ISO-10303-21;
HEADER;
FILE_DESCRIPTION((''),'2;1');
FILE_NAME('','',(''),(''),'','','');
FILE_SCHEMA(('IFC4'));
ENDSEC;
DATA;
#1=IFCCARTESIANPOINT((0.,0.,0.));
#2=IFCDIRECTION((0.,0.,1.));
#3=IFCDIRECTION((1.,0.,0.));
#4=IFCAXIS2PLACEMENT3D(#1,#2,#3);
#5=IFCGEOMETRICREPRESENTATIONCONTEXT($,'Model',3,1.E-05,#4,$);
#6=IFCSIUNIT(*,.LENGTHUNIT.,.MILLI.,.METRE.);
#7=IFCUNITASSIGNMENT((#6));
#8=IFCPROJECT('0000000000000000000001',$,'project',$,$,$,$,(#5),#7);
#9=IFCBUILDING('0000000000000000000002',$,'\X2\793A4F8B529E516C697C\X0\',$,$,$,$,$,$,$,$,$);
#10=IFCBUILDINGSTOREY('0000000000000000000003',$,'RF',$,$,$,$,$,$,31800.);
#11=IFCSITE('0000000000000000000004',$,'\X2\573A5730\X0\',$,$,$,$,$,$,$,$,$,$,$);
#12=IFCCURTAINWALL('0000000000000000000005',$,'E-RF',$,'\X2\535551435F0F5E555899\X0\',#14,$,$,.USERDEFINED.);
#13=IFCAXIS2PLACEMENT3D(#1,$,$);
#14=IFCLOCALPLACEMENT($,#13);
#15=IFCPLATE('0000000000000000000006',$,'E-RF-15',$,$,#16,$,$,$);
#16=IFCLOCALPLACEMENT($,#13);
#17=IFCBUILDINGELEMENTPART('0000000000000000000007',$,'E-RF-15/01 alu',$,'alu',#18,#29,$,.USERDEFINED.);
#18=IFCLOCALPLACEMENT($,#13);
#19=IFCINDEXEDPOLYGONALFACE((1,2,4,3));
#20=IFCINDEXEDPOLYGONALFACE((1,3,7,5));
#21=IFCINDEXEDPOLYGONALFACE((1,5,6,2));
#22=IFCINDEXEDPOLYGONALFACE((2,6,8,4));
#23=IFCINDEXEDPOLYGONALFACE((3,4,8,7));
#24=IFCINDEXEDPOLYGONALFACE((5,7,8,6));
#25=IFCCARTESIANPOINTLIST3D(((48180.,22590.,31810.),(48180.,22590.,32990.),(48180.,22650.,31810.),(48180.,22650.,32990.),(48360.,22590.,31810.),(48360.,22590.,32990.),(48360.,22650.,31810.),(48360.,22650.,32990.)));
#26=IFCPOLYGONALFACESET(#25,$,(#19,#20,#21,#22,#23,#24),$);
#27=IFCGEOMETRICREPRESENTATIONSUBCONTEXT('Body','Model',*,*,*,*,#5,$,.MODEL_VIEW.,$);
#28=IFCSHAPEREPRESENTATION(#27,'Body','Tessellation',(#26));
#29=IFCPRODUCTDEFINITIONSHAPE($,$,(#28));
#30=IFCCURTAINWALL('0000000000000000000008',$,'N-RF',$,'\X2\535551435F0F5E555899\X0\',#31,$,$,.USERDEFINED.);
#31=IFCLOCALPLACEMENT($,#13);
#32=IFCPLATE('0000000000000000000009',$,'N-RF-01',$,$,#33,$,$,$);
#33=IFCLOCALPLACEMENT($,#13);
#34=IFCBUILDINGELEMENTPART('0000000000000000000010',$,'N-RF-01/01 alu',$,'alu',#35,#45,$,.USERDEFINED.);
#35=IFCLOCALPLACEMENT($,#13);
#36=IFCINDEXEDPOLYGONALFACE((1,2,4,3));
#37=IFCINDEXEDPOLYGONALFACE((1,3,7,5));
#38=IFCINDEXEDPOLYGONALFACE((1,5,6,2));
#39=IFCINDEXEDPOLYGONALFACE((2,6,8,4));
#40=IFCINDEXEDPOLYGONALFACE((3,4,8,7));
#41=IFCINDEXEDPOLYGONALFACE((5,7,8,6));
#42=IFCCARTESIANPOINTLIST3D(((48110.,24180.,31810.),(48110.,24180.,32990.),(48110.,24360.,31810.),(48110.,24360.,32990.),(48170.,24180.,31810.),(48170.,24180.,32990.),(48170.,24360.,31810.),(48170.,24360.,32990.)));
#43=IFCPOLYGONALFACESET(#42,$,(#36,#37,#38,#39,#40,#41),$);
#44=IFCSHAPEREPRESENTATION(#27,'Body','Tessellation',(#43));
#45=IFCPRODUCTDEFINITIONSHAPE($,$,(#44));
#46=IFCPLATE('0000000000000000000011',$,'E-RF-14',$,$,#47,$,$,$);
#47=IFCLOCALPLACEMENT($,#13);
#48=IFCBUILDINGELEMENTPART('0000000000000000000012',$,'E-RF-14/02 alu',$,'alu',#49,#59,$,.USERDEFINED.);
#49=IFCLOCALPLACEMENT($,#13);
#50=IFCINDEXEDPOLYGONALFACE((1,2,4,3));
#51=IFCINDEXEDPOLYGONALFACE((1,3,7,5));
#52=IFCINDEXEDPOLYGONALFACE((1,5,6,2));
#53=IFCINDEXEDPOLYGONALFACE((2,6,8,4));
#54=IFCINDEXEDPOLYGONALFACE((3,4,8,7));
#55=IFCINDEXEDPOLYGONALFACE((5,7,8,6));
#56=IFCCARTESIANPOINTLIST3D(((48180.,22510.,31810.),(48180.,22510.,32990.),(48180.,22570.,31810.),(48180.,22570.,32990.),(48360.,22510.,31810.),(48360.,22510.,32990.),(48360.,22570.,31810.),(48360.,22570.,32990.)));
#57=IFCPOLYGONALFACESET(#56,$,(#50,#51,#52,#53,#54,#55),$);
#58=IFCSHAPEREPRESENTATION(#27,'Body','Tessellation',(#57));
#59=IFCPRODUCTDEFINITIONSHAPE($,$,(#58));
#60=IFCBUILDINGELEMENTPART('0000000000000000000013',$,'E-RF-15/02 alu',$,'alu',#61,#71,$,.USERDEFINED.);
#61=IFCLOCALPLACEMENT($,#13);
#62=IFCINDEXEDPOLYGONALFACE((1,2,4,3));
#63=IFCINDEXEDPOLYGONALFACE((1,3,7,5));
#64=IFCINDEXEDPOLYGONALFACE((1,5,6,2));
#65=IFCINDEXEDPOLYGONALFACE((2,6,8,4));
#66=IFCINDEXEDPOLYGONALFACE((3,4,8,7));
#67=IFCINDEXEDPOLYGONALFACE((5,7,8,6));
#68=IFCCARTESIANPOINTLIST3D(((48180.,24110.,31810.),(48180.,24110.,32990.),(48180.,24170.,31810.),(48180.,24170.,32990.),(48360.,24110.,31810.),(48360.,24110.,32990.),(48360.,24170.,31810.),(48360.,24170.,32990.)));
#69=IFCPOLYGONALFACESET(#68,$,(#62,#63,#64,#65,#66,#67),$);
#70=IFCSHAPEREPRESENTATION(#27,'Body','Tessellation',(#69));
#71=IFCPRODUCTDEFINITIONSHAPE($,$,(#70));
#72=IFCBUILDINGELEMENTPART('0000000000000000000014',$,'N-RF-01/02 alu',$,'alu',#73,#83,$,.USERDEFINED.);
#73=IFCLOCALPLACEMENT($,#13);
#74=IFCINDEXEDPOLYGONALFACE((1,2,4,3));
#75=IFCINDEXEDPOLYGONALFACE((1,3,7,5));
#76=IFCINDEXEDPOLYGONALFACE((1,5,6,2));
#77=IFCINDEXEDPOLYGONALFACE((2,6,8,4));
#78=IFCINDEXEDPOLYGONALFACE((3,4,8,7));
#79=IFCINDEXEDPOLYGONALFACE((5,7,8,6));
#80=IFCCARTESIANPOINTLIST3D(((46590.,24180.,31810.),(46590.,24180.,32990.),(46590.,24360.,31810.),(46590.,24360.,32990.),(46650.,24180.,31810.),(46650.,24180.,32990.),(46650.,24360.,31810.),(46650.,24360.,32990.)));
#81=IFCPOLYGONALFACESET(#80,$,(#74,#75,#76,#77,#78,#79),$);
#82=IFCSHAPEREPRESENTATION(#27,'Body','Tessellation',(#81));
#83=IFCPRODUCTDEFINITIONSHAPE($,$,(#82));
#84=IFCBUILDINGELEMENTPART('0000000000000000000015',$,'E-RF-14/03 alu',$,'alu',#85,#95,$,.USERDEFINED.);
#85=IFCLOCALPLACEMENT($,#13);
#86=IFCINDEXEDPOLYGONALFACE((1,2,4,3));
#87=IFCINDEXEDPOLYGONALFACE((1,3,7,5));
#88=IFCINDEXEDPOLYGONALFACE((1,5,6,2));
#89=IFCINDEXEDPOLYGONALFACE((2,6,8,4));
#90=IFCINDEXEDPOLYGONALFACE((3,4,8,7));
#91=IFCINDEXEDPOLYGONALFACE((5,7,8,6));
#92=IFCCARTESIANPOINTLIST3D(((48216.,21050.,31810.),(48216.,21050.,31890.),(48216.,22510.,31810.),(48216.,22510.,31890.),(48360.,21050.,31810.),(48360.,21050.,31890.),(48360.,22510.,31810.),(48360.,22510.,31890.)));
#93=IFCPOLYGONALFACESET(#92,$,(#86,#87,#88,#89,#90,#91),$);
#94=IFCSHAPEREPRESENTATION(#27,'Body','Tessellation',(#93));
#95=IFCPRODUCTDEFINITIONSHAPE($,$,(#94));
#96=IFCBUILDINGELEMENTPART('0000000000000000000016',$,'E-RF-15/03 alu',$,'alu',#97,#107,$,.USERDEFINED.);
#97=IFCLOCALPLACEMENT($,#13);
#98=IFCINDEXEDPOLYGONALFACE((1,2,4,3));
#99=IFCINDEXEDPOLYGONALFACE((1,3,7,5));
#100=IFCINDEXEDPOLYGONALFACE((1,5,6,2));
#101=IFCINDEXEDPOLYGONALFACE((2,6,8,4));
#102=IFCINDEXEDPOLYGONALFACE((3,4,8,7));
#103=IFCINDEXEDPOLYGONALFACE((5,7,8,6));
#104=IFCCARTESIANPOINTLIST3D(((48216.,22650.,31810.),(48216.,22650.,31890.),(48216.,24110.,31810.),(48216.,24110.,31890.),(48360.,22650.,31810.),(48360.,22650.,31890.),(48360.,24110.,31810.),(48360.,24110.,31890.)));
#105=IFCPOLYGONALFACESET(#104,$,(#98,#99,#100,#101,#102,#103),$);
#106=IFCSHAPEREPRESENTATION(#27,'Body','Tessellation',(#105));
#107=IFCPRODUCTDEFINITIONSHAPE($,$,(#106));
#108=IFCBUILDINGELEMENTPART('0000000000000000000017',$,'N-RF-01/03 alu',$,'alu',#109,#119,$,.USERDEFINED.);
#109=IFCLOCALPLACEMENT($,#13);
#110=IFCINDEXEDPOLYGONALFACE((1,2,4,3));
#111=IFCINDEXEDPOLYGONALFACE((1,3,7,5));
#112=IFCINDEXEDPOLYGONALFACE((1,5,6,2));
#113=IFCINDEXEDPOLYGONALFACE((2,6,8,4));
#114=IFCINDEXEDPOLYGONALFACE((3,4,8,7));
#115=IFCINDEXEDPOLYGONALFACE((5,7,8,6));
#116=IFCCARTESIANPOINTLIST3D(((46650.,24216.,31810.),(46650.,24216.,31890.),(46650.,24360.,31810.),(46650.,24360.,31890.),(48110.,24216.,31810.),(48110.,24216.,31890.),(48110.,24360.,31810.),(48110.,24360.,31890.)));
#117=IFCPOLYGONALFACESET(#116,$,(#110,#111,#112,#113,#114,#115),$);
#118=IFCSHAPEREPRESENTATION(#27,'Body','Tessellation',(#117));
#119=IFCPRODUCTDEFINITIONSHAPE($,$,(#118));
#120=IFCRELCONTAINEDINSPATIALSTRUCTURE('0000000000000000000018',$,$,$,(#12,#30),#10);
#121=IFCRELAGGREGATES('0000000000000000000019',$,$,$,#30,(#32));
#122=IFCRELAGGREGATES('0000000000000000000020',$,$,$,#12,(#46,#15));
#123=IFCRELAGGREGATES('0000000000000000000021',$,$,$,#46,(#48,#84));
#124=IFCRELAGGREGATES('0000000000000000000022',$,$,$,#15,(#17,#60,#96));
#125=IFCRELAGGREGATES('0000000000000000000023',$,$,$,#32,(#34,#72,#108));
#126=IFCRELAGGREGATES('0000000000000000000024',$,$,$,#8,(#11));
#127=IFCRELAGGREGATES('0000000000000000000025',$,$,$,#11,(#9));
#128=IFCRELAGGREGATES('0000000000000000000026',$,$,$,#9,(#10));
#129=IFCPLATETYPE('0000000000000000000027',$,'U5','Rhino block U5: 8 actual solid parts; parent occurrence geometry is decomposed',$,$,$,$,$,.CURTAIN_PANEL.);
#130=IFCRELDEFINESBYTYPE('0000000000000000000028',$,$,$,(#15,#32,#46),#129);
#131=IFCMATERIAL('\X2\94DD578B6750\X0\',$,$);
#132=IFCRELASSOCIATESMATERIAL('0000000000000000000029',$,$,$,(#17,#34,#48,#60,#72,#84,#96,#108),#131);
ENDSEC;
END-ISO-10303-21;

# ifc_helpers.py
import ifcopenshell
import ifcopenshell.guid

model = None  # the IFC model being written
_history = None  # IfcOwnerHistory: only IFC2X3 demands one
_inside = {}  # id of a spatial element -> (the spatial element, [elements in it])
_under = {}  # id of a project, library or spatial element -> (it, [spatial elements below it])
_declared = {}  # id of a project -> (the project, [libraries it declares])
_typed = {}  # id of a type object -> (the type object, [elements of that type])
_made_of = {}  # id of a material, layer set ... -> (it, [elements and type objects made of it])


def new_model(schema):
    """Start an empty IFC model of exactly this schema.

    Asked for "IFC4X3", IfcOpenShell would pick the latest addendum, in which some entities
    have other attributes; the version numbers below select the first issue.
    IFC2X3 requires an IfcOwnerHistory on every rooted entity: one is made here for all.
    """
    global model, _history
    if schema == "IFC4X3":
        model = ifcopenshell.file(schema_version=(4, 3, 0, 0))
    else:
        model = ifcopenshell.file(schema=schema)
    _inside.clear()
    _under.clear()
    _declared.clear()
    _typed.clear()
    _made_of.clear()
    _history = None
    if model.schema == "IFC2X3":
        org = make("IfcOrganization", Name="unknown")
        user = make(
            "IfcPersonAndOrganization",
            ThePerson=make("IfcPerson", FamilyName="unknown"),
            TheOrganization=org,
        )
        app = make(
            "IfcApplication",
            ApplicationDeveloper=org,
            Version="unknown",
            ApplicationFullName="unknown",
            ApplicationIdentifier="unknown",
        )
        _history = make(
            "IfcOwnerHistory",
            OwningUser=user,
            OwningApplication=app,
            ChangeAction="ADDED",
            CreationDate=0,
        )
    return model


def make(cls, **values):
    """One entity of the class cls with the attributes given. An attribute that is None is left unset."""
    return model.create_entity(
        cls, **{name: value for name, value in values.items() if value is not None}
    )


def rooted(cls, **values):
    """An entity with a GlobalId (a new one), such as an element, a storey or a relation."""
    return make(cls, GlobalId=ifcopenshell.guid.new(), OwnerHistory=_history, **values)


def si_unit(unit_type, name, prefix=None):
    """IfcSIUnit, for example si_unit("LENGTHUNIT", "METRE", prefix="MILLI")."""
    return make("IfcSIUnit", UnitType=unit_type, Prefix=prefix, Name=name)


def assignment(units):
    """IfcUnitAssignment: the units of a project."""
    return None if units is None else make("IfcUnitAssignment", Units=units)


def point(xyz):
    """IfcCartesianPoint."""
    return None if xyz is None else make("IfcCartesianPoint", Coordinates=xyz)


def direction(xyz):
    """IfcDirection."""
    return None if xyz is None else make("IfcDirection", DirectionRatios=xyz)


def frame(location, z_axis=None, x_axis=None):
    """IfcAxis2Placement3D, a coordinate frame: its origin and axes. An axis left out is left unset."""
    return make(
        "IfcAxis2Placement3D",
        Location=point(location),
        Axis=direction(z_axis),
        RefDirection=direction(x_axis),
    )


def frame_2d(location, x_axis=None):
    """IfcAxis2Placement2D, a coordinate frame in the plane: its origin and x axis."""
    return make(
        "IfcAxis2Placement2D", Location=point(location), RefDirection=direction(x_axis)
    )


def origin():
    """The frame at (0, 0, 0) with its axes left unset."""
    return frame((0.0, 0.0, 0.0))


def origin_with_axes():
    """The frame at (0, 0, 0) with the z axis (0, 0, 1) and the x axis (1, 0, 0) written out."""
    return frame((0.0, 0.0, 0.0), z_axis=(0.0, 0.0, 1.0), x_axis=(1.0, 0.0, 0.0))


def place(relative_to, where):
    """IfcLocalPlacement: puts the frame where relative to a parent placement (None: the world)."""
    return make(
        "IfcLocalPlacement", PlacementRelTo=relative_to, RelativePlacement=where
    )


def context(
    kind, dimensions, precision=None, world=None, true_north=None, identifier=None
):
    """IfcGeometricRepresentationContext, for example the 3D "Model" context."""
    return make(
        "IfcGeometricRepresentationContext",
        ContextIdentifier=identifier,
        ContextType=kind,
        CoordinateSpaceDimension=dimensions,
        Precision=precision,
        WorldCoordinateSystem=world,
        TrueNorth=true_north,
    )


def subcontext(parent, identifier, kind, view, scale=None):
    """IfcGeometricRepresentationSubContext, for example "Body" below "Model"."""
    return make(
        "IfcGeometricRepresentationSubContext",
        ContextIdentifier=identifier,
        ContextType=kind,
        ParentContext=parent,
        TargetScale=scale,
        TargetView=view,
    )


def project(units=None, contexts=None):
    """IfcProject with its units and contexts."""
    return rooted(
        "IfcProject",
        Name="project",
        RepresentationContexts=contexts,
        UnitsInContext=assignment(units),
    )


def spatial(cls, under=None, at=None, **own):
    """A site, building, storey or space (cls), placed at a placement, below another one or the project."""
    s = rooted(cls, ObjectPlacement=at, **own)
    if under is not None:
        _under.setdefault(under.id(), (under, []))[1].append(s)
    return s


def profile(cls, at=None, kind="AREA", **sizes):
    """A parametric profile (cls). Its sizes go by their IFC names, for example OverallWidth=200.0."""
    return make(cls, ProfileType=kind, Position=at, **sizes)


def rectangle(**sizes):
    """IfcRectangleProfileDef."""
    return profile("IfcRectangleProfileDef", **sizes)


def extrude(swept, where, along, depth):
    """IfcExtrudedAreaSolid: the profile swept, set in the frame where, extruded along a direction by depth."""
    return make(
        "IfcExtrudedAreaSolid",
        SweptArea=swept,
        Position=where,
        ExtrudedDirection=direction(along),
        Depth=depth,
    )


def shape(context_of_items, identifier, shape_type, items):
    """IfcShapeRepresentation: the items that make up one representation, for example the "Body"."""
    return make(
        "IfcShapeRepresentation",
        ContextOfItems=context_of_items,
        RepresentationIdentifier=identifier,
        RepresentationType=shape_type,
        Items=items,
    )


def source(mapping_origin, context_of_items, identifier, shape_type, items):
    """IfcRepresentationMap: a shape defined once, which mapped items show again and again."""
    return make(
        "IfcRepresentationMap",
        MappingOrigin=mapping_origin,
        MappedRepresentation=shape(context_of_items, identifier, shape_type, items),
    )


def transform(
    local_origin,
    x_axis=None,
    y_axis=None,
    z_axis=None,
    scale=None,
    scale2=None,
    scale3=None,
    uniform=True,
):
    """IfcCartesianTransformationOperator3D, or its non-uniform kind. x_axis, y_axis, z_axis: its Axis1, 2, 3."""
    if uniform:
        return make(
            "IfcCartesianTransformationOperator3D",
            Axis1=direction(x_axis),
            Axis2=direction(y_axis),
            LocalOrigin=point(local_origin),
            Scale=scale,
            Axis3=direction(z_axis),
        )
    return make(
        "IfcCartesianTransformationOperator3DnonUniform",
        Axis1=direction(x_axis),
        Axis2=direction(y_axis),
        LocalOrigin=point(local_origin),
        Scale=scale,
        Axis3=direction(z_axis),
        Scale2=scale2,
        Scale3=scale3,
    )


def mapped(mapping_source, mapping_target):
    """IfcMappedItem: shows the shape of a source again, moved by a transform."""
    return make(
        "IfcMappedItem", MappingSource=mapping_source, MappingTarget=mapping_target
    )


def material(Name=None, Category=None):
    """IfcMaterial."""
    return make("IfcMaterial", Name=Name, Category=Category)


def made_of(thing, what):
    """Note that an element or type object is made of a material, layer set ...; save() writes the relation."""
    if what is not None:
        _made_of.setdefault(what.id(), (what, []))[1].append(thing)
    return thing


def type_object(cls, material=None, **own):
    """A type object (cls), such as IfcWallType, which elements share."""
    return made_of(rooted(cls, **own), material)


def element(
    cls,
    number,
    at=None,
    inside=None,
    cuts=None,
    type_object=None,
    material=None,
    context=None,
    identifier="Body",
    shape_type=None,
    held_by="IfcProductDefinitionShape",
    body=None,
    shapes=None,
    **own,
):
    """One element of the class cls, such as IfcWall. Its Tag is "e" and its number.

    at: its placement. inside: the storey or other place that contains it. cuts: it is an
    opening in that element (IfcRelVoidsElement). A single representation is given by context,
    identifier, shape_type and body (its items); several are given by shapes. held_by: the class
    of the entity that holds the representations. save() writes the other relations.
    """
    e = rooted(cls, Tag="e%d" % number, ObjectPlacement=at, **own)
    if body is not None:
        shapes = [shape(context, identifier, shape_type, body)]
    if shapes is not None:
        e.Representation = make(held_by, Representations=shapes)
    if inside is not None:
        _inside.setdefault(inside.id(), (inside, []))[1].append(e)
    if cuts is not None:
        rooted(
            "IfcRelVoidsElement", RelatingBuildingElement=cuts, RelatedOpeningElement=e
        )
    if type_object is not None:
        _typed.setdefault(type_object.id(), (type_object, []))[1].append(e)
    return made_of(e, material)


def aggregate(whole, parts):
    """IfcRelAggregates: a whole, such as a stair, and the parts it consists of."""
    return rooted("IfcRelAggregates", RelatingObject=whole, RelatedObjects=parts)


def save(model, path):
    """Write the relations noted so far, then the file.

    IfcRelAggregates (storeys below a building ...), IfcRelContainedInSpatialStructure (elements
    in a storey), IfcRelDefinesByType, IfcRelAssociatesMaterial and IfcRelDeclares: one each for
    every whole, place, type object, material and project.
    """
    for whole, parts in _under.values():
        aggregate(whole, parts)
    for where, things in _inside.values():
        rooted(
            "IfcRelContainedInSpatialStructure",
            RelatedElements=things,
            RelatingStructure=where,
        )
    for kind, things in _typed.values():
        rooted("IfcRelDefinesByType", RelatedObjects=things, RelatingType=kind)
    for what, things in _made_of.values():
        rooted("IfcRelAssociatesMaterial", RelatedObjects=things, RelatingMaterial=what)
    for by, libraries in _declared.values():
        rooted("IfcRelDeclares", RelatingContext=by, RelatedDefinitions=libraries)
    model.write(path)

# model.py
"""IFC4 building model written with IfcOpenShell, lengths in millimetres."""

from ifc_helpers import new_model, si_unit, frame, frame_2d, origin, origin_with_axes, place, context, subcontext, project, spatial, rectangle, extrude, source, transform, mapped, material, type_object, element, aggregate, save


model = new_model("IFC4")

# Units and contexts
model_context = context("Model", 3, precision=1e-05, world=origin_with_axes())
body_context = subcontext(model_context, "Body", "Model", "MODEL_VIEW")
ifc_project = project(units=[si_unit("LENGTHUNIT", "METRE", prefix="MILLI")], contexts=[model_context])

# Site, building, storey
site = spatial("IfcSite", under=ifc_project, Name="场地")
building = spatial("IfcBuilding", under=site, Name="示例办公楼")
storey = spatial("IfcBuildingStorey", under=building, Name="RF", Elevation=31800.0)

# Curtain walls, plates, building element parts
curtain_wall_1 = element("IfcCurtainWall", 1, inside=storey, Name="E-RF", ObjectType="单元式幕墙", PredefinedType="USERDEFINED")
plate_type = type_object("IfcPlateType", Name="U5", Description="Rhino block U5: 8 actual solid parts; parent occurrence geometry is decomposed", PredefinedType="CURTAIN_PANEL")
plate_1_placement = place(None, frame((48360.0, 22590.0, 31810.0), z_axis=(0.0, 0.0, 1.0), x_axis=(0.0, 1.0, 0.0)))
plate_1 = element("IfcPlate", 2, at=plate_1_placement, type_object=plate_type, Name="E-RF-15")
ifc_material_1 = material(Name="铝型材")
shared_shape_1 = source(origin(), body_context, "Body", "SweptSolid", [
    extrude(rectangle(XDim=60.0, YDim=180.0, at=frame_2d((30.0, 90.0))), origin(), (0.0, 0.0, 1.0), 1180.0),
])
building_element_part_1_placement = place(plate_1_placement, origin())
building_element_part_1 = element("IfcBuildingElementPart", 3, at=building_element_part_1_placement, material=ifc_material_1, Name="E-RF-15/01 alu", ObjectType="alu", PredefinedType="USERDEFINED", context=body_context, shape_type="MappedRepresentation", body=[
    mapped(shared_shape_1, transform((0.0, 0.0, 0.0))),
])
curtain_wall_2 = element("IfcCurtainWall", 4, inside=storey, Name="N-RF", ObjectType="单元式幕墙", PredefinedType="USERDEFINED")
plate_2_placement = place(None, frame((48170.0, 24360.0, 31810.0), z_axis=(0.0, 0.0, 1.0), x_axis=(-1.0, 0.0, 0.0)))
plate_2 = element("IfcPlate", 5, at=plate_2_placement, type_object=plate_type, Name="N-RF-01")
aggregate(curtain_wall_2, [plate_2])
building_element_part_2_placement = place(plate_2_placement, origin())
building_element_part_2 = element("IfcBuildingElementPart", 6, at=building_element_part_2_placement, material=ifc_material_1, Name="N-RF-01/01 alu", ObjectType="alu", PredefinedType="USERDEFINED", context=body_context, shape_type="MappedRepresentation", body=[
    mapped(shared_shape_1, transform((0.0, 0.0, 0.0))),
])

# Plate
plate_3_placement = place(None, frame((48360.0, 20990.0, 31810.0), z_axis=(0.0, 0.0, 1.0), x_axis=(0.0, 1.0, 0.0)))
plate_3 = element("IfcPlate", 7, at=plate_3_placement, type_object=plate_type, Name="E-RF-14")
aggregate(curtain_wall_1, [plate_3, plate_1])

# Building element parts
shared_shape_2 = source(origin(), body_context, "Body", "SweptSolid", [
    extrude(rectangle(XDim=60.0, YDim=180.0, at=frame_2d((1550.0, 90.0))), origin(), (0.0, 0.0, 1.0), 1180.0),
])
building_element_part_3_placement = place(plate_3_placement, origin())
building_element_part_3 = element("IfcBuildingElementPart", 8, at=building_element_part_3_placement, material=ifc_material_1, Name="E-RF-14/02 alu", ObjectType="alu", PredefinedType="USERDEFINED", context=body_context, shape_type="MappedRepresentation", body=[
    mapped(shared_shape_2, transform((0.0, 0.0, 0.0))),
])
building_element_part_4_placement = place(plate_1_placement, origin())
building_element_part_4 = element("IfcBuildingElementPart", 9, at=building_element_part_4_placement, material=ifc_material_1, Name="E-RF-15/02 alu", ObjectType="alu", PredefinedType="USERDEFINED", context=body_context, shape_type="MappedRepresentation", body=[
    mapped(shared_shape_2, transform((0.0, 0.0, 0.0))),
])
building_element_part_5_placement = place(plate_2_placement, origin())
building_element_part_5 = element("IfcBuildingElementPart", 10, at=building_element_part_5_placement, material=ifc_material_1, Name="N-RF-01/02 alu", ObjectType="alu", PredefinedType="USERDEFINED", context=body_context, shape_type="MappedRepresentation", body=[
    mapped(shared_shape_2, transform((0.0, 0.0, 0.0))),
])
shared_shape_3 = source(origin(), body_context, "Body", "SweptSolid", [
    extrude(rectangle(XDim=1460.0, YDim=144.0, at=frame_2d((790.0, 72.0))), origin(), (0.0, 0.0, 1.0), 80.0),
])
building_element_part_6_placement = place(plate_3_placement, origin())
building_element_part_6 = element("IfcBuildingElementPart", 11, at=building_element_part_6_placement, material=ifc_material_1, Name="E-RF-14/03 alu", ObjectType="alu", PredefinedType="USERDEFINED", context=body_context, shape_type="MappedRepresentation", body=[
    mapped(shared_shape_3, transform((0.0, 0.0, 0.0))),
])
building_element_part_7_placement = place(plate_1_placement, origin())
building_element_part_7 = element("IfcBuildingElementPart", 12, at=building_element_part_7_placement, material=ifc_material_1, Name="E-RF-15/03 alu", ObjectType="alu", PredefinedType="USERDEFINED", context=body_context, shape_type="MappedRepresentation", body=[
    mapped(shared_shape_3, transform((0.0, 0.0, 0.0))),
])
building_element_part_8_placement = place(plate_2_placement, origin())
building_element_part_8 = element("IfcBuildingElementPart", 13, at=building_element_part_8_placement, material=ifc_material_1, Name="N-RF-01/03 alu", ObjectType="alu", PredefinedType="USERDEFINED", context=body_context, shape_type="MappedRepresentation", body=[
    mapped(shared_shape_3, transform((0.0, 0.0, 0.0))),
])
aggregate(plate_3, [building_element_part_3, building_element_part_6])
aggregate(plate_1, [building_element_part_1, building_element_part_4, building_element_part_7])
aggregate(plate_2, [building_element_part_2, building_element_part_5, building_element_part_8])

save(model, "model.ifc")
